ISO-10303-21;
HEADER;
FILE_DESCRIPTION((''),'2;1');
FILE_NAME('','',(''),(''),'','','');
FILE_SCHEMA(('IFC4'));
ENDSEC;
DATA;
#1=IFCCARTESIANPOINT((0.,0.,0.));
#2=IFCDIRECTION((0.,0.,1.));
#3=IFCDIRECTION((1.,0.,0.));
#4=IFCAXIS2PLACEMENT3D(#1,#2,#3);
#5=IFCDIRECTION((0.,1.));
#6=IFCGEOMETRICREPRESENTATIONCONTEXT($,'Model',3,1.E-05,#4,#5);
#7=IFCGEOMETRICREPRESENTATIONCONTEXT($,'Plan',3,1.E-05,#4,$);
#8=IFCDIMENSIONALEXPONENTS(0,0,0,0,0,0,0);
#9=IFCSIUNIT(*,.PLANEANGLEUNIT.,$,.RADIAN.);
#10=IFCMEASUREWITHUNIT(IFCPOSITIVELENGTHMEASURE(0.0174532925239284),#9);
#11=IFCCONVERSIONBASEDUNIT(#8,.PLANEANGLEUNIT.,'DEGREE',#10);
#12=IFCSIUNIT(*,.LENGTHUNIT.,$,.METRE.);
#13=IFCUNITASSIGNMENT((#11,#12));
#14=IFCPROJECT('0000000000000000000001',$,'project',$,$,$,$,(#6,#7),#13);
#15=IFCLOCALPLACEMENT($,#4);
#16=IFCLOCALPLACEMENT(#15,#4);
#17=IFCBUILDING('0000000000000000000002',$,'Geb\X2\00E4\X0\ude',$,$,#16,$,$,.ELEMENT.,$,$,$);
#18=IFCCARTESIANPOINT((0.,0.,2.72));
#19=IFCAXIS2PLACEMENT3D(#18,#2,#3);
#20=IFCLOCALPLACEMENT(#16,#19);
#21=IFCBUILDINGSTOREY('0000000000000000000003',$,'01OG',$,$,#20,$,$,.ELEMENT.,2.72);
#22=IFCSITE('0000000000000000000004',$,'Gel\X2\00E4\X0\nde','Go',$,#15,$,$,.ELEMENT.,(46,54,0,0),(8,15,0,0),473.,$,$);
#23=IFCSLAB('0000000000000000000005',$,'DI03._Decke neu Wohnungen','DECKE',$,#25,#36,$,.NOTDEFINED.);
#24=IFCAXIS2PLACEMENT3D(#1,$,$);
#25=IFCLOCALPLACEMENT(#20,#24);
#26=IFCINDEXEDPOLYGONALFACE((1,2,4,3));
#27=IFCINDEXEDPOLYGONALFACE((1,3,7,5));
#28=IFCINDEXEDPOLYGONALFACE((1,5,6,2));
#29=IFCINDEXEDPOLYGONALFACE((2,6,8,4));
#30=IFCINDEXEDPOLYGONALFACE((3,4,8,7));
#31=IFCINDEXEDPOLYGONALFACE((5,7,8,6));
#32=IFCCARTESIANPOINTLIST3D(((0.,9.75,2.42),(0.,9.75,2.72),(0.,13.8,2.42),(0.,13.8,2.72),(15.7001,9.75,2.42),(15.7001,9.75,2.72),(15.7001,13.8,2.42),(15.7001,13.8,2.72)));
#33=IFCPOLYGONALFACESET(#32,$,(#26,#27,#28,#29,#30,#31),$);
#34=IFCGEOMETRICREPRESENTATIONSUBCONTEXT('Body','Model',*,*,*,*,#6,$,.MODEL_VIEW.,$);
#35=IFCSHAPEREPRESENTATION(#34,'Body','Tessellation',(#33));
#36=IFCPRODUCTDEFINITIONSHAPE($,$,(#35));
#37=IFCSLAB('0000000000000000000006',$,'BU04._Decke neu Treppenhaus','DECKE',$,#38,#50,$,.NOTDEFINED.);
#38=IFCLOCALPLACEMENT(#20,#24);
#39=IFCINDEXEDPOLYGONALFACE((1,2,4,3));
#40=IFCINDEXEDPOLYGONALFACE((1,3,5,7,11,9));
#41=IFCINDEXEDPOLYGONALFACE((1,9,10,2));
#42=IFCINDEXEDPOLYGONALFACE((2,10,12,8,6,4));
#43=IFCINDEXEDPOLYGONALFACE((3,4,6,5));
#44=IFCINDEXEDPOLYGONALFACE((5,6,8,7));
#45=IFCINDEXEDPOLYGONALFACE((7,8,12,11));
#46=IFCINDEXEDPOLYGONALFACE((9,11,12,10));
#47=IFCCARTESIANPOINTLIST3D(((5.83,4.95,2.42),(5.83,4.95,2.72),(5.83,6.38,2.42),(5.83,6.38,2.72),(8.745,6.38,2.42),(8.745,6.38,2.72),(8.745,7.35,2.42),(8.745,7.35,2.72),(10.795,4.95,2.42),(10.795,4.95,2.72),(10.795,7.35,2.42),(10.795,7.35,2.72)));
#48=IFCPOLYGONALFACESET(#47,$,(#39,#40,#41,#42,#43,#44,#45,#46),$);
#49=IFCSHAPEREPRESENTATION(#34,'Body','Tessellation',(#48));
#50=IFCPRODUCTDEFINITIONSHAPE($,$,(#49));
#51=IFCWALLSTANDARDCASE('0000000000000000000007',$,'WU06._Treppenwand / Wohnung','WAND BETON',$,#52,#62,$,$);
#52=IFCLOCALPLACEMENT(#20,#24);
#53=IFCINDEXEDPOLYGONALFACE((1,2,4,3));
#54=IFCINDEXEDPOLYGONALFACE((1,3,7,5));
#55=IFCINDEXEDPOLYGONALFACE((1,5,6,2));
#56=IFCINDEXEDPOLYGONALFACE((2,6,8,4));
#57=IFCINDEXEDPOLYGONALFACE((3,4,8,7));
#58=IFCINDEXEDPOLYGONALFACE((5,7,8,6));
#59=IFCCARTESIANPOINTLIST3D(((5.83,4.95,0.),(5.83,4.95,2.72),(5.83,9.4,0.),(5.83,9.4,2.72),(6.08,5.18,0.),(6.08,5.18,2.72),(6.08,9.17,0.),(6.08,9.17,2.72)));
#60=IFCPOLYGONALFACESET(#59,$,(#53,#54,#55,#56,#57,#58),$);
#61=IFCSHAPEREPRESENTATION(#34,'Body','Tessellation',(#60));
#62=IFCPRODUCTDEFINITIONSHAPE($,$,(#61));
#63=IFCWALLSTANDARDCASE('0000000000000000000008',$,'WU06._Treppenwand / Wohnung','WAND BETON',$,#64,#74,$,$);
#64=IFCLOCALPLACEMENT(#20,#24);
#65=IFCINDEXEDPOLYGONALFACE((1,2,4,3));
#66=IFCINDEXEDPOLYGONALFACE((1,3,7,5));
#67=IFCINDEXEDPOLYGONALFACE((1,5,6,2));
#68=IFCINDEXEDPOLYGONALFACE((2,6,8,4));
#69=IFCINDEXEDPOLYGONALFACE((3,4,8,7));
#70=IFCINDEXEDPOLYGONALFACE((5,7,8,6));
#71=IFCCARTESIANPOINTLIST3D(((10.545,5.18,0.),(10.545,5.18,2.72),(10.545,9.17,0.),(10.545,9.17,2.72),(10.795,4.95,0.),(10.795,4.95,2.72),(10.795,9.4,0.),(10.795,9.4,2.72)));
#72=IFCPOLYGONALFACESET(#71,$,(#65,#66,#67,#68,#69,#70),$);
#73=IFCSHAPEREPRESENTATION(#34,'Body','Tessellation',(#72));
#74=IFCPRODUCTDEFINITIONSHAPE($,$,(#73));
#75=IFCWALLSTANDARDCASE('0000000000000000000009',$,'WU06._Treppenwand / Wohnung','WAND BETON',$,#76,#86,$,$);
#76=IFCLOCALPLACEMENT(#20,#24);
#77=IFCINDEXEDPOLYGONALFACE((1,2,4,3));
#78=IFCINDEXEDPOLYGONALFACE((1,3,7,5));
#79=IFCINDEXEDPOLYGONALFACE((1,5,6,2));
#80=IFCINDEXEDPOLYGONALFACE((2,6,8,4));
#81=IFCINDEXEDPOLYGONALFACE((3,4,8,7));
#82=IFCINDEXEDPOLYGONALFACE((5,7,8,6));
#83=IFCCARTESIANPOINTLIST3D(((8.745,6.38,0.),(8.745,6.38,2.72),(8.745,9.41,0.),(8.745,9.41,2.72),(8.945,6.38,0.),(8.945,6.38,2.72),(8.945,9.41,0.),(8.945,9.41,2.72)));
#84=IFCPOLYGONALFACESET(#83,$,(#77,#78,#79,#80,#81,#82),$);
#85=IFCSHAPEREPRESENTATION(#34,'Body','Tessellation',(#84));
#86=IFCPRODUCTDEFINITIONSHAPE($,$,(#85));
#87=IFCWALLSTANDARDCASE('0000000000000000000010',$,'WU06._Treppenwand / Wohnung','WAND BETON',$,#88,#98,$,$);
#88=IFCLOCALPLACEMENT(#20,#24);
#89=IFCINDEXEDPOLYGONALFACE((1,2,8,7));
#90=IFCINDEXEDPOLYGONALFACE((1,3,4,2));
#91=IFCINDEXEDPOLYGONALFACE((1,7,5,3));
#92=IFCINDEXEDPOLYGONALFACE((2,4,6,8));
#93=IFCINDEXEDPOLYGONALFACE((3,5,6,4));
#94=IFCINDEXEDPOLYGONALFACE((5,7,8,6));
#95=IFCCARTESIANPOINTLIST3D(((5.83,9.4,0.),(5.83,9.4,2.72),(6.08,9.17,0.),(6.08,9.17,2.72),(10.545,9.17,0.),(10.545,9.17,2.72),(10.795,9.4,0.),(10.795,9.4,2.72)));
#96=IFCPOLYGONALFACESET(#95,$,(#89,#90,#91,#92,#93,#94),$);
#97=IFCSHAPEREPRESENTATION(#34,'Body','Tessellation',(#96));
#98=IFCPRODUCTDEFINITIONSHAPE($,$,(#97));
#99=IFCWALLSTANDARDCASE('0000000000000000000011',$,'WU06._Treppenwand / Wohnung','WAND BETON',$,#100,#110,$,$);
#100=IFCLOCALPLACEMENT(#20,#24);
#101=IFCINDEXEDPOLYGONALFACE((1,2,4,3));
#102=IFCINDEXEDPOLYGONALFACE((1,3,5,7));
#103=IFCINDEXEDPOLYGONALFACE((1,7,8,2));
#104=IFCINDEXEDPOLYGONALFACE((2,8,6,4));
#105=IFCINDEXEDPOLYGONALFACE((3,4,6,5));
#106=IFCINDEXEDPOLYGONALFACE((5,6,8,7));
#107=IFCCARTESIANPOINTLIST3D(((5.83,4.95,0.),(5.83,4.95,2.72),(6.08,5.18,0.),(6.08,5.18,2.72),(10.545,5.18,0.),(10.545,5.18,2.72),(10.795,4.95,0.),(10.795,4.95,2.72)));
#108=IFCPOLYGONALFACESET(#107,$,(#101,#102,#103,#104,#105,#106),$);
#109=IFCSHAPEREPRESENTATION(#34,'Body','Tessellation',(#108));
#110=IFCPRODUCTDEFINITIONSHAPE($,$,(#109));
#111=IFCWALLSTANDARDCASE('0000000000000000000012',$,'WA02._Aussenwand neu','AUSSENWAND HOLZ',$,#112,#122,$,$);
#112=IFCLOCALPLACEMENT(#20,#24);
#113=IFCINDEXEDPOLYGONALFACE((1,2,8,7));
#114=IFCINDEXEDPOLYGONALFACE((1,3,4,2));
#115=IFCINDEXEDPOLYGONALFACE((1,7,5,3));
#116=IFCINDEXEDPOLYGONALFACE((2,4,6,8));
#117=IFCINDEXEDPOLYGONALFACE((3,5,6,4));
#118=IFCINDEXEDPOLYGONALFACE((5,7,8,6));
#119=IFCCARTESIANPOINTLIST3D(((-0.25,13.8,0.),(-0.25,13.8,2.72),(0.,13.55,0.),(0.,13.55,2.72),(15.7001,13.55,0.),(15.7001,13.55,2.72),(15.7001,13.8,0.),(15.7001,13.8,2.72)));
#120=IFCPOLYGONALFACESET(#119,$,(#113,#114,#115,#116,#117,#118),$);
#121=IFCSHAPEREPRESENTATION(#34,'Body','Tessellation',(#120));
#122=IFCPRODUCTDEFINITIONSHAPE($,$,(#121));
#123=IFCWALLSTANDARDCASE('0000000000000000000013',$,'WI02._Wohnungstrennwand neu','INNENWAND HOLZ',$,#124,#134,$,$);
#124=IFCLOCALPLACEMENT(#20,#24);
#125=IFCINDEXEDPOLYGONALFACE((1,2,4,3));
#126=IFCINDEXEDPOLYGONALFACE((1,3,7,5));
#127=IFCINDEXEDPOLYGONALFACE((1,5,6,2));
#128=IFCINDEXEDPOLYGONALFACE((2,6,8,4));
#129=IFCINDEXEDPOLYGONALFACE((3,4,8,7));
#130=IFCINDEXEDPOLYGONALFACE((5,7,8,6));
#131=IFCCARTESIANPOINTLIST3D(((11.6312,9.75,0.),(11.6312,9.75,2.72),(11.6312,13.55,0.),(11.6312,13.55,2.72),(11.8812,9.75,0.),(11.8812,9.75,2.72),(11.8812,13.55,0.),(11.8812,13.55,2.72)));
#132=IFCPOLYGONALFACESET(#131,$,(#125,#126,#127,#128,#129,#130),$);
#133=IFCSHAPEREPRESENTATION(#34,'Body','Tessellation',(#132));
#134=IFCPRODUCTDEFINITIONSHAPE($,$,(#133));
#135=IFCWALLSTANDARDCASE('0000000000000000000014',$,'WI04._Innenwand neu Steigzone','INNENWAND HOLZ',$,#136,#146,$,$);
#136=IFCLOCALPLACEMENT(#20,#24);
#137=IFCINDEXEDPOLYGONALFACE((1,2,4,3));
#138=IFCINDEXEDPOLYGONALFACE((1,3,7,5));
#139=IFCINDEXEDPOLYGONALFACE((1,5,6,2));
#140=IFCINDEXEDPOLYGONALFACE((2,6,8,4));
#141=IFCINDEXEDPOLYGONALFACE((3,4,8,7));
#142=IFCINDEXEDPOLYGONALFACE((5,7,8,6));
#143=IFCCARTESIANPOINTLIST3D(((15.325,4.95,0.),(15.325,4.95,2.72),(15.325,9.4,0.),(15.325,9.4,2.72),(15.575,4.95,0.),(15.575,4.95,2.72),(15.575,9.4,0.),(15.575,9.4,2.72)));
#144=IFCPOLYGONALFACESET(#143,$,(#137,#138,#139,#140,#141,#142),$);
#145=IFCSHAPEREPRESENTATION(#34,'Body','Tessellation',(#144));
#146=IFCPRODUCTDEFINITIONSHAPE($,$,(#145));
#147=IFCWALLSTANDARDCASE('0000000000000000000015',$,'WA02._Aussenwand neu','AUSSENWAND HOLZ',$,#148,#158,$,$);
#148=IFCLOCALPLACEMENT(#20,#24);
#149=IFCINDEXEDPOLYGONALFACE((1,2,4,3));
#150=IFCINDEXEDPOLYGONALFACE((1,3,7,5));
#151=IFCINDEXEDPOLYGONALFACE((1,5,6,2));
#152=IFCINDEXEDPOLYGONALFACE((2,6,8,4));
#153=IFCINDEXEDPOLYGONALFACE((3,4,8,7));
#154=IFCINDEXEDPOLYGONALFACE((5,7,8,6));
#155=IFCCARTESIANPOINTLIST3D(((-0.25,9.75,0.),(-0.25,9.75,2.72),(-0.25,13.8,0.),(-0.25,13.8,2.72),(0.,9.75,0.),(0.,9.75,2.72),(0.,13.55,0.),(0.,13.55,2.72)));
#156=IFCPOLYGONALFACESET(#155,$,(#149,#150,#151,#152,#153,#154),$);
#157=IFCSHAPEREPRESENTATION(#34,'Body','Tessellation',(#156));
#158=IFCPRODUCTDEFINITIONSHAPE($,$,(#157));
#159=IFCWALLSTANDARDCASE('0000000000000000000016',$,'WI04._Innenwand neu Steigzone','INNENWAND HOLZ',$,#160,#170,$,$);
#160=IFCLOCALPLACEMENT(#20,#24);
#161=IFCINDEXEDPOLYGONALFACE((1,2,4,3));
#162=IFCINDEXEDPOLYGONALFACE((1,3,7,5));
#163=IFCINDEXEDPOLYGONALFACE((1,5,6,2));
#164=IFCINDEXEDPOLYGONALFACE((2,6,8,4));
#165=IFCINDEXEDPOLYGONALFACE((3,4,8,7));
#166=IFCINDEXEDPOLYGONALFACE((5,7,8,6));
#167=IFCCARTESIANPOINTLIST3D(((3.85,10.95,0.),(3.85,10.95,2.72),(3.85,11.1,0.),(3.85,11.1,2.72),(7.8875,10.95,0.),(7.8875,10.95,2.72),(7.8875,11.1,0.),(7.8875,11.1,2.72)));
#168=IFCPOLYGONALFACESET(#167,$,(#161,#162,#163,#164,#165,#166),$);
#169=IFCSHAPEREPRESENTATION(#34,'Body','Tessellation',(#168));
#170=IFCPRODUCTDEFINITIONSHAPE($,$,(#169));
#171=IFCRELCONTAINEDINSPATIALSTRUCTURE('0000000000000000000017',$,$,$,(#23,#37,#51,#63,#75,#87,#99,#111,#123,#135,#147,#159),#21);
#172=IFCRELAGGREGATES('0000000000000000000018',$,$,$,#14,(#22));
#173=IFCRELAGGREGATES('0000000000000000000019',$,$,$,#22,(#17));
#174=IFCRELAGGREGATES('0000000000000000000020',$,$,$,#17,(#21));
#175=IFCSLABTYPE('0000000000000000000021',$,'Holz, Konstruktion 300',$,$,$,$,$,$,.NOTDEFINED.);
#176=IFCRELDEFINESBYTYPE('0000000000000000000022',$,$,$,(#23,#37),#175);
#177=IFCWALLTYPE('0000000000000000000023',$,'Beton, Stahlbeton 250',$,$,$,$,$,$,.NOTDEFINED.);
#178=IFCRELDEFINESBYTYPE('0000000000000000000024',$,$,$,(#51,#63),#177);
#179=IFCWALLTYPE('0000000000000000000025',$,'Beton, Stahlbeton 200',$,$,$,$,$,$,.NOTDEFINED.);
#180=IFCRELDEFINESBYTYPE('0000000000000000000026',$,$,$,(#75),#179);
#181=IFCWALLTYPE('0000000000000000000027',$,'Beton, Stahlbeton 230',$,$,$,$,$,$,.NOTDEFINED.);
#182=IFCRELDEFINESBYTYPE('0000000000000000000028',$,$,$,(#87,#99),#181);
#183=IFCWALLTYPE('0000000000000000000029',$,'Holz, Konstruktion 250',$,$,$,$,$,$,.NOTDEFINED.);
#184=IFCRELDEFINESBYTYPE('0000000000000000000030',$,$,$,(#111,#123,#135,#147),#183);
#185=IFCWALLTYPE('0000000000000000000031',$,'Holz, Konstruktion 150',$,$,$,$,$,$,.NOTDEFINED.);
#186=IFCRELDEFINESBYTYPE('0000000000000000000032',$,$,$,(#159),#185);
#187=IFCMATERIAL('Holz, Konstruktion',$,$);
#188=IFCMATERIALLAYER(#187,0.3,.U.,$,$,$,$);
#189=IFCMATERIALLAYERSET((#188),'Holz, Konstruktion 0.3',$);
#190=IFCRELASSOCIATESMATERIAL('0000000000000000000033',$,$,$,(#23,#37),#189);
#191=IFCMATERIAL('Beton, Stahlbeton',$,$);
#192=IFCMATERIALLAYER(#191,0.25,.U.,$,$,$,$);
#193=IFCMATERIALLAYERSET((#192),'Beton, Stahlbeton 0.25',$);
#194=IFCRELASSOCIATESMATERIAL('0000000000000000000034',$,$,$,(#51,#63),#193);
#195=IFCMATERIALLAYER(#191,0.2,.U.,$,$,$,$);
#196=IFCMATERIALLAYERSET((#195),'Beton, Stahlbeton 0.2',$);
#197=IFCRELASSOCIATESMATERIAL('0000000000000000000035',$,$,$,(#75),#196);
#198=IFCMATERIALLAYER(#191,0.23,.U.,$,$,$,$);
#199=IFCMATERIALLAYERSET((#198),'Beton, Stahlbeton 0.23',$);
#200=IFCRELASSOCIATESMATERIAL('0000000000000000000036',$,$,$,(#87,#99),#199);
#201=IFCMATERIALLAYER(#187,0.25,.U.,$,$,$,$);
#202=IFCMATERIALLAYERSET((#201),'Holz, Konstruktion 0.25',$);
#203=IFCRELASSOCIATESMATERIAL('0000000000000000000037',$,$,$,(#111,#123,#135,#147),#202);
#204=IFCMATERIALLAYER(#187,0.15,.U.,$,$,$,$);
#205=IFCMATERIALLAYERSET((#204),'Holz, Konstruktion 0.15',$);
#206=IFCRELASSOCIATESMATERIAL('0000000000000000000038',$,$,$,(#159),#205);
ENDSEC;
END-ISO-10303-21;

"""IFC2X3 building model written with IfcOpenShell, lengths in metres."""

from ifc_helpers import new_model, entity, si_unit, converted_unit, direction, frame, origin_with_axes, place, context, subcontext, project, spatial, polyline, outline, extrude, material, layer, layer_set, layer_usage, type_object, element, save


model = new_model("IFC2X3")

# Units and contexts
model_context = context("Model", 3, precision=1e-05, world=origin_with_axes(), true_north=direction((0.0, 1.0)))
plan_context = context("Plan", 3, precision=1e-05, world=origin_with_axes())
body_context = subcontext(model_context, "Body", "Model", "MODEL_VIEW")
ifc_project = project(units=[converted_unit("PLANEANGLEUNIT", "DEGREE", entity("IfcPositiveLengthMeasure", 0.0174532925239284), si_unit("PLANEANGLEUNIT", "RADIAN"), dimensions=[0, 0, 0, 0, 0, 0, 0]), si_unit("LENGTHUNIT", "METRE")], contexts=[model_context, plan_context])

# Site, building, storey
site_placement = place(None, origin_with_axes())
site = spatial("IfcSite", under=ifc_project, at=site_placement, Name="Gelände", Description="Go", CompositionType="ELEMENT", RefLatitude=(46, 54, 0, 0), RefLongitude=(8, 15, 0, 0), RefElevation=473.0)
building_placement = place(site_placement, origin_with_axes())
building = spatial("IfcBuilding", under=site, at=building_placement, Name="Gebäude", CompositionType="ELEMENT")
storey_placement = place(building_placement, frame((0.0, 0.0, 2.72), z_axis=(0.0, 0.0, 1.0), x_axis=(1.0, 0.0, 0.0)))
storey = spatial("IfcBuildingStorey", under=building, at=storey_placement, Name="01OG", CompositionType="ELEMENT", Elevation=2.72)

# Slabs
ifc_material_1 = material(Name="Holz, Konstruktion")
ifc_layer_1 = layer(ifc_material_1, 0.3, ventilated="UNKNOWN")
ifc_layer_set_1 = layer_set([ifc_layer_1], Name="Holz, Konstruktion 0.3")
ifc_layer_usage_1 = layer_usage(ifc_layer_set_1, "AXIS3", "NEGATIVE", 0.3)
slab_type = type_object("IfcSlabType", Name="Holz, Konstruktion 300", PredefinedType="NOTDEFINED")
slab_1_placement = place(storey_placement, frame((0.0, 9.75, 2.72), z_axis=(0.0, 0.0, 1.0), x_axis=(1.0, 0.0, 0.0)))
element("IfcSlab", 1, at=slab_1_placement, inside=storey, type_object=slab_type, material=ifc_layer_usage_1, Name="DI03._Decke neu Wohnungen", Description="DECKE", PredefinedType="NOTDEFINED", context=body_context, shape_type="SweptSolid", body=[
    extrude(outline(polyline([(0.0, 0.0), (15.7001, 0.0), (15.7001, 4.05), (0.0, 4.05), (0.0, 0.0)])), frame((0.0, 0.0, -0.3), z_axis=(0.0, 0.0, 1.0), x_axis=(1.0, 0.0, 0.0)), (0.0, 0.0, 1.0), 0.3),
])
ifc_layer_usage_2 = layer_usage(ifc_layer_set_1, "AXIS3", "NEGATIVE", 0.3)
slab_2_placement = place(storey_placement, frame((10.795, 7.35, 2.72), z_axis=(0.0, 0.0, 1.0), x_axis=(1.0, 0.0, 0.0)))
element("IfcSlab", 2, at=slab_2_placement, inside=storey, type_object=slab_type, material=ifc_layer_usage_2, Name="BU04._Decke neu Treppenhaus", Description="DECKE", PredefinedType="NOTDEFINED", context=body_context, shape_type="SweptSolid", body=[
    extrude(outline(polyline([(0.0, 0.0), (-2.05, 0.0), (-2.05, -0.97), (-4.965, -0.97), (-4.965, -2.4), (0.0, -2.4), (0.0, 0.0)])), frame((0.0, 0.0, -0.3), z_axis=(0.0, 0.0, 1.0), x_axis=(1.0, 0.0, 0.0)), (0.0, 0.0, 1.0), 0.3),
])

# Walls
ifc_material_2 = material(Name="Beton, Stahlbeton")
ifc_layer_2 = layer(ifc_material_2, 0.25, ventilated="UNKNOWN")
ifc_layer_set_2 = layer_set([ifc_layer_2], Name="Beton, Stahlbeton 0.25")
ifc_layer_usage_3 = layer_usage(ifc_layer_set_2, "AXIS2", "POSITIVE", -0.25)
wall_type_1 = type_object("IfcWallType", Name="Beton, Stahlbeton 250", PredefinedType="NOTDEFINED")
wall_1_placement = place(storey_placement, frame((6.08, 9.17, 0.0), z_axis=(0.0, 0.0, 1.0), x_axis=(0.0, -1.0, 0.0)))
element("IfcWallStandardCase", 3, at=wall_1_placement, inside=storey, type_object=wall_type_1, material=ifc_layer_usage_3, Name="WU06._Treppenwand / Wohnung", Description="WAND BETON", context=body_context, shape_type="SweptSolid", body=[
    extrude(outline(polyline([(-0.23, -0.25), (4.22, -0.25), (3.99, 0.0), (0.0, 0.0), (-0.23, -0.25)])), origin_with_axes(), (0.0, 0.0, 1.0), 2.72),
])
ifc_layer_usage_4 = layer_usage(ifc_layer_set_2, "AXIS2", "POSITIVE", -0.25)
wall_2_placement = place(storey_placement, frame((10.545, 5.18, 0.0), z_axis=(0.0, 0.0, 1.0), x_axis=(0.0, 1.0, 0.0)))
element("IfcWallStandardCase", 4, at=wall_2_placement, inside=storey, type_object=wall_type_1, material=ifc_layer_usage_4, Name="WU06._Treppenwand / Wohnung", Description="WAND BETON", context=body_context, shape_type="SweptSolid", body=[
    extrude(outline(polyline([(-0.23, -0.25), (4.22, -0.25), (3.99, 0.0), (0.0, 0.0), (-0.23, -0.25)])), origin_with_axes(), (0.0, 0.0, 1.0), 2.72),
])
ifc_layer_3 = layer(ifc_material_2, 0.2, ventilated="UNKNOWN")
ifc_layer_set_3 = layer_set([ifc_layer_3], Name="Beton, Stahlbeton 0.2")
ifc_layer_usage_5 = layer_usage(ifc_layer_set_3, "AXIS2", "NEGATIVE", 0.2)
wall_type_2 = type_object("IfcWallType", Name="Beton, Stahlbeton 200", PredefinedType="NOTDEFINED")
wall_3_placement = place(storey_placement, frame((8.945, 6.38, 0.0), z_axis=(0.0, 0.0, 1.0), x_axis=(0.0, 1.0, 0.0)))
element("IfcWallStandardCase", 5, at=wall_3_placement, inside=storey, type_object=wall_type_2, material=ifc_layer_usage_5, Name="WU06._Treppenwand / Wohnung", Description="WAND BETON", context=body_context, shape_type="SweptSolid", body=[
    extrude(outline(polyline([(0.0, 0.0), (3.03, 0.0), (3.03, 0.2), (0.0, 0.2), (0.0, 0.0)])), origin_with_axes(), (0.0, 0.0, 1.0), 2.72),
])
ifc_layer_4 = layer(ifc_material_2, 0.23, ventilated="UNKNOWN")
ifc_layer_set_4 = layer_set([ifc_layer_4], Name="Beton, Stahlbeton 0.23")
ifc_layer_usage_6 = layer_usage(ifc_layer_set_4, "AXIS2", "POSITIVE", -0.23)
wall_type_3 = type_object("IfcWallType", Name="Beton, Stahlbeton 230", PredefinedType="NOTDEFINED")
wall_4_placement = place(storey_placement, frame((10.545, 9.17, 0.0), z_axis=(0.0, 0.0, 1.0), x_axis=(-1.0, 0.0, 0.0)))
element("IfcWallStandardCase", 6, at=wall_4_placement, inside=storey, type_object=wall_type_3, material=ifc_layer_usage_6, Name="WU06._Treppenwand / Wohnung", Description="WAND BETON", context=body_context, shape_type="SweptSolid", body=[
    extrude(outline(polyline([(-0.25, -0.23), (4.715, -0.23), (4.465, 0.0), (0.0, 0.0), (-0.25, -0.23)])), origin_with_axes(), (0.0, 0.0, 1.0), 2.72),
])
ifc_layer_usage_7 = layer_usage(ifc_layer_set_4, "AXIS2", "POSITIVE", -0.23)
wall_5_placement = place(storey_placement, frame((6.08, 5.18, 0.0), z_axis=(0.0, 0.0, 1.0), x_axis=(1.0, 0.0, 0.0)))
element("IfcWallStandardCase", 7, at=wall_5_placement, inside=storey, type_object=wall_type_3, material=ifc_layer_usage_7, Name="WU06._Treppenwand / Wohnung", Description="WAND BETON", context=body_context, shape_type="SweptSolid", body=[
    extrude(outline(polyline([(-0.25, -0.23), (4.715, -0.23), (4.465, 0.0), (0.0, 0.0), (-0.25, -0.23)])), origin_with_axes(), (0.0, 0.0, 1.0), 2.72),
])
ifc_layer_5 = layer(ifc_material_1, 0.25, ventilated="UNKNOWN")
ifc_layer_set_5 = layer_set([ifc_layer_5], Name="Holz, Konstruktion 0.25")
ifc_layer_usage_8 = layer_usage(ifc_layer_set_5, "AXIS2", "NEGATIVE", 0.0)
wall_type_4 = type_object("IfcWallType", Name="Holz, Konstruktion 250", PredefinedType="NOTDEFINED")
wall_6_placement = place(storey_placement, frame((-0.25, 13.8, 0.0), z_axis=(0.0, 0.0, 1.0), x_axis=(1.0, 0.0, 0.0)))
element("IfcWallStandardCase", 8, at=wall_6_placement, inside=storey, type_object=wall_type_4, material=ifc_layer_usage_8, Name="WA02._Aussenwand neu", Description="AUSSENWAND HOLZ", context=body_context, shape_type="SweptSolid", body=[
    extrude(outline(polyline([(0.25, -0.25), (15.9501, -0.25), (15.9501, 0.0), (0.0, 0.0), (0.25, -0.25)])), origin_with_axes(), (0.0, 0.0, 1.0), 2.72),
])
ifc_layer_usage_9 = layer_usage(ifc_layer_set_5, "AXIS2", "NEGATIVE", 0.0)
wall_7_placement = place(storey_placement, frame((11.8812, 13.55, 0.0), z_axis=(0.0, 0.0, 1.0), x_axis=(0.0, -1.0, 0.0)))
element("IfcWallStandardCase", 9, at=wall_7_placement, inside=storey, type_object=wall_type_4, material=ifc_layer_usage_9, Name="WI02._Wohnungstrennwand neu", Description="INNENWAND HOLZ", context=body_context, shape_type="SweptSolid", body=[
    extrude(outline(polyline([(0.0, -0.25), (3.8, -0.25), (3.8, 0.0), (0.0, 0.0), (0.0, -0.25)])), origin_with_axes(), (0.0, 0.0, 1.0), 2.72),
])
ifc_layer_usage_10 = layer_usage(ifc_layer_set_5, "AXIS2", "NEGATIVE", 0.0)
wall_8_placement = place(storey_placement, frame((15.325, 4.95, 0.0), z_axis=(0.0, 0.0, 1.0), x_axis=(0.0, 1.0, 0.0)))
element("IfcWallStandardCase", 10, at=wall_8_placement, inside=storey, type_object=wall_type_4, material=ifc_layer_usage_10, Name="WI04._Innenwand neu Steigzone", Description="INNENWAND HOLZ", context=body_context, shape_type="SweptSolid", body=[
    extrude(outline(polyline([(0.0, -0.25), (4.45, -0.25), (4.45, 0.0), (0.0, 0.0), (0.0, -0.25)])), origin_with_axes(), (0.0, 0.0, 1.0), 2.72),
])
ifc_layer_usage_11 = layer_usage(ifc_layer_set_5, "AXIS2", "NEGATIVE", 0.0)
wall_9_placement = place(storey_placement, frame((-0.25, 9.75, 0.0), z_axis=(0.0, 0.0, 1.0), x_axis=(0.0, 1.0, 0.0)))
element("IfcWallStandardCase", 11, at=wall_9_placement, inside=storey, type_object=wall_type_4, material=ifc_layer_usage_11, Name="WA02._Aussenwand neu", Description="AUSSENWAND HOLZ", context=body_context, shape_type="SweptSolid", body=[
    extrude(outline(polyline([(0.0, -0.25), (3.8, -0.25), (4.05, 0.0), (0.0, 0.0), (0.0, -0.25)])), origin_with_axes(), (0.0, 0.0, 1.0), 2.72),
])
ifc_layer_6 = layer(ifc_material_1, 0.15, ventilated="UNKNOWN")
ifc_layer_set_6 = layer_set([ifc_layer_6], Name="Holz, Konstruktion 0.15")
ifc_layer_usage_12 = layer_usage(ifc_layer_set_6, "AXIS2", "POSITIVE", 0.0)
wall_type_5 = type_object("IfcWallType", Name="Holz, Konstruktion 150", PredefinedType="NOTDEFINED")
wall_10_placement = place(storey_placement, frame((3.85, 10.95, 0.0), z_axis=(0.0, 0.0, 1.0), x_axis=(1.0, 0.0, 0.0)))
element("IfcWallStandardCase", 12, at=wall_10_placement, inside=storey, type_object=wall_type_5, material=ifc_layer_usage_12, Name="WI04._Innenwand neu Steigzone", Description="INNENWAND HOLZ", context=body_context, shape_type="SweptSolid", body=[
    extrude(outline(polyline([(0.0, 0.0), (4.0375, 0.0), (4.0375, 0.15), (0.0, 0.15), (0.0, 0.0)])), origin_with_axes(), (0.0, 0.0, 1.0), 2.72),
])

save(model, "model.ifc")
